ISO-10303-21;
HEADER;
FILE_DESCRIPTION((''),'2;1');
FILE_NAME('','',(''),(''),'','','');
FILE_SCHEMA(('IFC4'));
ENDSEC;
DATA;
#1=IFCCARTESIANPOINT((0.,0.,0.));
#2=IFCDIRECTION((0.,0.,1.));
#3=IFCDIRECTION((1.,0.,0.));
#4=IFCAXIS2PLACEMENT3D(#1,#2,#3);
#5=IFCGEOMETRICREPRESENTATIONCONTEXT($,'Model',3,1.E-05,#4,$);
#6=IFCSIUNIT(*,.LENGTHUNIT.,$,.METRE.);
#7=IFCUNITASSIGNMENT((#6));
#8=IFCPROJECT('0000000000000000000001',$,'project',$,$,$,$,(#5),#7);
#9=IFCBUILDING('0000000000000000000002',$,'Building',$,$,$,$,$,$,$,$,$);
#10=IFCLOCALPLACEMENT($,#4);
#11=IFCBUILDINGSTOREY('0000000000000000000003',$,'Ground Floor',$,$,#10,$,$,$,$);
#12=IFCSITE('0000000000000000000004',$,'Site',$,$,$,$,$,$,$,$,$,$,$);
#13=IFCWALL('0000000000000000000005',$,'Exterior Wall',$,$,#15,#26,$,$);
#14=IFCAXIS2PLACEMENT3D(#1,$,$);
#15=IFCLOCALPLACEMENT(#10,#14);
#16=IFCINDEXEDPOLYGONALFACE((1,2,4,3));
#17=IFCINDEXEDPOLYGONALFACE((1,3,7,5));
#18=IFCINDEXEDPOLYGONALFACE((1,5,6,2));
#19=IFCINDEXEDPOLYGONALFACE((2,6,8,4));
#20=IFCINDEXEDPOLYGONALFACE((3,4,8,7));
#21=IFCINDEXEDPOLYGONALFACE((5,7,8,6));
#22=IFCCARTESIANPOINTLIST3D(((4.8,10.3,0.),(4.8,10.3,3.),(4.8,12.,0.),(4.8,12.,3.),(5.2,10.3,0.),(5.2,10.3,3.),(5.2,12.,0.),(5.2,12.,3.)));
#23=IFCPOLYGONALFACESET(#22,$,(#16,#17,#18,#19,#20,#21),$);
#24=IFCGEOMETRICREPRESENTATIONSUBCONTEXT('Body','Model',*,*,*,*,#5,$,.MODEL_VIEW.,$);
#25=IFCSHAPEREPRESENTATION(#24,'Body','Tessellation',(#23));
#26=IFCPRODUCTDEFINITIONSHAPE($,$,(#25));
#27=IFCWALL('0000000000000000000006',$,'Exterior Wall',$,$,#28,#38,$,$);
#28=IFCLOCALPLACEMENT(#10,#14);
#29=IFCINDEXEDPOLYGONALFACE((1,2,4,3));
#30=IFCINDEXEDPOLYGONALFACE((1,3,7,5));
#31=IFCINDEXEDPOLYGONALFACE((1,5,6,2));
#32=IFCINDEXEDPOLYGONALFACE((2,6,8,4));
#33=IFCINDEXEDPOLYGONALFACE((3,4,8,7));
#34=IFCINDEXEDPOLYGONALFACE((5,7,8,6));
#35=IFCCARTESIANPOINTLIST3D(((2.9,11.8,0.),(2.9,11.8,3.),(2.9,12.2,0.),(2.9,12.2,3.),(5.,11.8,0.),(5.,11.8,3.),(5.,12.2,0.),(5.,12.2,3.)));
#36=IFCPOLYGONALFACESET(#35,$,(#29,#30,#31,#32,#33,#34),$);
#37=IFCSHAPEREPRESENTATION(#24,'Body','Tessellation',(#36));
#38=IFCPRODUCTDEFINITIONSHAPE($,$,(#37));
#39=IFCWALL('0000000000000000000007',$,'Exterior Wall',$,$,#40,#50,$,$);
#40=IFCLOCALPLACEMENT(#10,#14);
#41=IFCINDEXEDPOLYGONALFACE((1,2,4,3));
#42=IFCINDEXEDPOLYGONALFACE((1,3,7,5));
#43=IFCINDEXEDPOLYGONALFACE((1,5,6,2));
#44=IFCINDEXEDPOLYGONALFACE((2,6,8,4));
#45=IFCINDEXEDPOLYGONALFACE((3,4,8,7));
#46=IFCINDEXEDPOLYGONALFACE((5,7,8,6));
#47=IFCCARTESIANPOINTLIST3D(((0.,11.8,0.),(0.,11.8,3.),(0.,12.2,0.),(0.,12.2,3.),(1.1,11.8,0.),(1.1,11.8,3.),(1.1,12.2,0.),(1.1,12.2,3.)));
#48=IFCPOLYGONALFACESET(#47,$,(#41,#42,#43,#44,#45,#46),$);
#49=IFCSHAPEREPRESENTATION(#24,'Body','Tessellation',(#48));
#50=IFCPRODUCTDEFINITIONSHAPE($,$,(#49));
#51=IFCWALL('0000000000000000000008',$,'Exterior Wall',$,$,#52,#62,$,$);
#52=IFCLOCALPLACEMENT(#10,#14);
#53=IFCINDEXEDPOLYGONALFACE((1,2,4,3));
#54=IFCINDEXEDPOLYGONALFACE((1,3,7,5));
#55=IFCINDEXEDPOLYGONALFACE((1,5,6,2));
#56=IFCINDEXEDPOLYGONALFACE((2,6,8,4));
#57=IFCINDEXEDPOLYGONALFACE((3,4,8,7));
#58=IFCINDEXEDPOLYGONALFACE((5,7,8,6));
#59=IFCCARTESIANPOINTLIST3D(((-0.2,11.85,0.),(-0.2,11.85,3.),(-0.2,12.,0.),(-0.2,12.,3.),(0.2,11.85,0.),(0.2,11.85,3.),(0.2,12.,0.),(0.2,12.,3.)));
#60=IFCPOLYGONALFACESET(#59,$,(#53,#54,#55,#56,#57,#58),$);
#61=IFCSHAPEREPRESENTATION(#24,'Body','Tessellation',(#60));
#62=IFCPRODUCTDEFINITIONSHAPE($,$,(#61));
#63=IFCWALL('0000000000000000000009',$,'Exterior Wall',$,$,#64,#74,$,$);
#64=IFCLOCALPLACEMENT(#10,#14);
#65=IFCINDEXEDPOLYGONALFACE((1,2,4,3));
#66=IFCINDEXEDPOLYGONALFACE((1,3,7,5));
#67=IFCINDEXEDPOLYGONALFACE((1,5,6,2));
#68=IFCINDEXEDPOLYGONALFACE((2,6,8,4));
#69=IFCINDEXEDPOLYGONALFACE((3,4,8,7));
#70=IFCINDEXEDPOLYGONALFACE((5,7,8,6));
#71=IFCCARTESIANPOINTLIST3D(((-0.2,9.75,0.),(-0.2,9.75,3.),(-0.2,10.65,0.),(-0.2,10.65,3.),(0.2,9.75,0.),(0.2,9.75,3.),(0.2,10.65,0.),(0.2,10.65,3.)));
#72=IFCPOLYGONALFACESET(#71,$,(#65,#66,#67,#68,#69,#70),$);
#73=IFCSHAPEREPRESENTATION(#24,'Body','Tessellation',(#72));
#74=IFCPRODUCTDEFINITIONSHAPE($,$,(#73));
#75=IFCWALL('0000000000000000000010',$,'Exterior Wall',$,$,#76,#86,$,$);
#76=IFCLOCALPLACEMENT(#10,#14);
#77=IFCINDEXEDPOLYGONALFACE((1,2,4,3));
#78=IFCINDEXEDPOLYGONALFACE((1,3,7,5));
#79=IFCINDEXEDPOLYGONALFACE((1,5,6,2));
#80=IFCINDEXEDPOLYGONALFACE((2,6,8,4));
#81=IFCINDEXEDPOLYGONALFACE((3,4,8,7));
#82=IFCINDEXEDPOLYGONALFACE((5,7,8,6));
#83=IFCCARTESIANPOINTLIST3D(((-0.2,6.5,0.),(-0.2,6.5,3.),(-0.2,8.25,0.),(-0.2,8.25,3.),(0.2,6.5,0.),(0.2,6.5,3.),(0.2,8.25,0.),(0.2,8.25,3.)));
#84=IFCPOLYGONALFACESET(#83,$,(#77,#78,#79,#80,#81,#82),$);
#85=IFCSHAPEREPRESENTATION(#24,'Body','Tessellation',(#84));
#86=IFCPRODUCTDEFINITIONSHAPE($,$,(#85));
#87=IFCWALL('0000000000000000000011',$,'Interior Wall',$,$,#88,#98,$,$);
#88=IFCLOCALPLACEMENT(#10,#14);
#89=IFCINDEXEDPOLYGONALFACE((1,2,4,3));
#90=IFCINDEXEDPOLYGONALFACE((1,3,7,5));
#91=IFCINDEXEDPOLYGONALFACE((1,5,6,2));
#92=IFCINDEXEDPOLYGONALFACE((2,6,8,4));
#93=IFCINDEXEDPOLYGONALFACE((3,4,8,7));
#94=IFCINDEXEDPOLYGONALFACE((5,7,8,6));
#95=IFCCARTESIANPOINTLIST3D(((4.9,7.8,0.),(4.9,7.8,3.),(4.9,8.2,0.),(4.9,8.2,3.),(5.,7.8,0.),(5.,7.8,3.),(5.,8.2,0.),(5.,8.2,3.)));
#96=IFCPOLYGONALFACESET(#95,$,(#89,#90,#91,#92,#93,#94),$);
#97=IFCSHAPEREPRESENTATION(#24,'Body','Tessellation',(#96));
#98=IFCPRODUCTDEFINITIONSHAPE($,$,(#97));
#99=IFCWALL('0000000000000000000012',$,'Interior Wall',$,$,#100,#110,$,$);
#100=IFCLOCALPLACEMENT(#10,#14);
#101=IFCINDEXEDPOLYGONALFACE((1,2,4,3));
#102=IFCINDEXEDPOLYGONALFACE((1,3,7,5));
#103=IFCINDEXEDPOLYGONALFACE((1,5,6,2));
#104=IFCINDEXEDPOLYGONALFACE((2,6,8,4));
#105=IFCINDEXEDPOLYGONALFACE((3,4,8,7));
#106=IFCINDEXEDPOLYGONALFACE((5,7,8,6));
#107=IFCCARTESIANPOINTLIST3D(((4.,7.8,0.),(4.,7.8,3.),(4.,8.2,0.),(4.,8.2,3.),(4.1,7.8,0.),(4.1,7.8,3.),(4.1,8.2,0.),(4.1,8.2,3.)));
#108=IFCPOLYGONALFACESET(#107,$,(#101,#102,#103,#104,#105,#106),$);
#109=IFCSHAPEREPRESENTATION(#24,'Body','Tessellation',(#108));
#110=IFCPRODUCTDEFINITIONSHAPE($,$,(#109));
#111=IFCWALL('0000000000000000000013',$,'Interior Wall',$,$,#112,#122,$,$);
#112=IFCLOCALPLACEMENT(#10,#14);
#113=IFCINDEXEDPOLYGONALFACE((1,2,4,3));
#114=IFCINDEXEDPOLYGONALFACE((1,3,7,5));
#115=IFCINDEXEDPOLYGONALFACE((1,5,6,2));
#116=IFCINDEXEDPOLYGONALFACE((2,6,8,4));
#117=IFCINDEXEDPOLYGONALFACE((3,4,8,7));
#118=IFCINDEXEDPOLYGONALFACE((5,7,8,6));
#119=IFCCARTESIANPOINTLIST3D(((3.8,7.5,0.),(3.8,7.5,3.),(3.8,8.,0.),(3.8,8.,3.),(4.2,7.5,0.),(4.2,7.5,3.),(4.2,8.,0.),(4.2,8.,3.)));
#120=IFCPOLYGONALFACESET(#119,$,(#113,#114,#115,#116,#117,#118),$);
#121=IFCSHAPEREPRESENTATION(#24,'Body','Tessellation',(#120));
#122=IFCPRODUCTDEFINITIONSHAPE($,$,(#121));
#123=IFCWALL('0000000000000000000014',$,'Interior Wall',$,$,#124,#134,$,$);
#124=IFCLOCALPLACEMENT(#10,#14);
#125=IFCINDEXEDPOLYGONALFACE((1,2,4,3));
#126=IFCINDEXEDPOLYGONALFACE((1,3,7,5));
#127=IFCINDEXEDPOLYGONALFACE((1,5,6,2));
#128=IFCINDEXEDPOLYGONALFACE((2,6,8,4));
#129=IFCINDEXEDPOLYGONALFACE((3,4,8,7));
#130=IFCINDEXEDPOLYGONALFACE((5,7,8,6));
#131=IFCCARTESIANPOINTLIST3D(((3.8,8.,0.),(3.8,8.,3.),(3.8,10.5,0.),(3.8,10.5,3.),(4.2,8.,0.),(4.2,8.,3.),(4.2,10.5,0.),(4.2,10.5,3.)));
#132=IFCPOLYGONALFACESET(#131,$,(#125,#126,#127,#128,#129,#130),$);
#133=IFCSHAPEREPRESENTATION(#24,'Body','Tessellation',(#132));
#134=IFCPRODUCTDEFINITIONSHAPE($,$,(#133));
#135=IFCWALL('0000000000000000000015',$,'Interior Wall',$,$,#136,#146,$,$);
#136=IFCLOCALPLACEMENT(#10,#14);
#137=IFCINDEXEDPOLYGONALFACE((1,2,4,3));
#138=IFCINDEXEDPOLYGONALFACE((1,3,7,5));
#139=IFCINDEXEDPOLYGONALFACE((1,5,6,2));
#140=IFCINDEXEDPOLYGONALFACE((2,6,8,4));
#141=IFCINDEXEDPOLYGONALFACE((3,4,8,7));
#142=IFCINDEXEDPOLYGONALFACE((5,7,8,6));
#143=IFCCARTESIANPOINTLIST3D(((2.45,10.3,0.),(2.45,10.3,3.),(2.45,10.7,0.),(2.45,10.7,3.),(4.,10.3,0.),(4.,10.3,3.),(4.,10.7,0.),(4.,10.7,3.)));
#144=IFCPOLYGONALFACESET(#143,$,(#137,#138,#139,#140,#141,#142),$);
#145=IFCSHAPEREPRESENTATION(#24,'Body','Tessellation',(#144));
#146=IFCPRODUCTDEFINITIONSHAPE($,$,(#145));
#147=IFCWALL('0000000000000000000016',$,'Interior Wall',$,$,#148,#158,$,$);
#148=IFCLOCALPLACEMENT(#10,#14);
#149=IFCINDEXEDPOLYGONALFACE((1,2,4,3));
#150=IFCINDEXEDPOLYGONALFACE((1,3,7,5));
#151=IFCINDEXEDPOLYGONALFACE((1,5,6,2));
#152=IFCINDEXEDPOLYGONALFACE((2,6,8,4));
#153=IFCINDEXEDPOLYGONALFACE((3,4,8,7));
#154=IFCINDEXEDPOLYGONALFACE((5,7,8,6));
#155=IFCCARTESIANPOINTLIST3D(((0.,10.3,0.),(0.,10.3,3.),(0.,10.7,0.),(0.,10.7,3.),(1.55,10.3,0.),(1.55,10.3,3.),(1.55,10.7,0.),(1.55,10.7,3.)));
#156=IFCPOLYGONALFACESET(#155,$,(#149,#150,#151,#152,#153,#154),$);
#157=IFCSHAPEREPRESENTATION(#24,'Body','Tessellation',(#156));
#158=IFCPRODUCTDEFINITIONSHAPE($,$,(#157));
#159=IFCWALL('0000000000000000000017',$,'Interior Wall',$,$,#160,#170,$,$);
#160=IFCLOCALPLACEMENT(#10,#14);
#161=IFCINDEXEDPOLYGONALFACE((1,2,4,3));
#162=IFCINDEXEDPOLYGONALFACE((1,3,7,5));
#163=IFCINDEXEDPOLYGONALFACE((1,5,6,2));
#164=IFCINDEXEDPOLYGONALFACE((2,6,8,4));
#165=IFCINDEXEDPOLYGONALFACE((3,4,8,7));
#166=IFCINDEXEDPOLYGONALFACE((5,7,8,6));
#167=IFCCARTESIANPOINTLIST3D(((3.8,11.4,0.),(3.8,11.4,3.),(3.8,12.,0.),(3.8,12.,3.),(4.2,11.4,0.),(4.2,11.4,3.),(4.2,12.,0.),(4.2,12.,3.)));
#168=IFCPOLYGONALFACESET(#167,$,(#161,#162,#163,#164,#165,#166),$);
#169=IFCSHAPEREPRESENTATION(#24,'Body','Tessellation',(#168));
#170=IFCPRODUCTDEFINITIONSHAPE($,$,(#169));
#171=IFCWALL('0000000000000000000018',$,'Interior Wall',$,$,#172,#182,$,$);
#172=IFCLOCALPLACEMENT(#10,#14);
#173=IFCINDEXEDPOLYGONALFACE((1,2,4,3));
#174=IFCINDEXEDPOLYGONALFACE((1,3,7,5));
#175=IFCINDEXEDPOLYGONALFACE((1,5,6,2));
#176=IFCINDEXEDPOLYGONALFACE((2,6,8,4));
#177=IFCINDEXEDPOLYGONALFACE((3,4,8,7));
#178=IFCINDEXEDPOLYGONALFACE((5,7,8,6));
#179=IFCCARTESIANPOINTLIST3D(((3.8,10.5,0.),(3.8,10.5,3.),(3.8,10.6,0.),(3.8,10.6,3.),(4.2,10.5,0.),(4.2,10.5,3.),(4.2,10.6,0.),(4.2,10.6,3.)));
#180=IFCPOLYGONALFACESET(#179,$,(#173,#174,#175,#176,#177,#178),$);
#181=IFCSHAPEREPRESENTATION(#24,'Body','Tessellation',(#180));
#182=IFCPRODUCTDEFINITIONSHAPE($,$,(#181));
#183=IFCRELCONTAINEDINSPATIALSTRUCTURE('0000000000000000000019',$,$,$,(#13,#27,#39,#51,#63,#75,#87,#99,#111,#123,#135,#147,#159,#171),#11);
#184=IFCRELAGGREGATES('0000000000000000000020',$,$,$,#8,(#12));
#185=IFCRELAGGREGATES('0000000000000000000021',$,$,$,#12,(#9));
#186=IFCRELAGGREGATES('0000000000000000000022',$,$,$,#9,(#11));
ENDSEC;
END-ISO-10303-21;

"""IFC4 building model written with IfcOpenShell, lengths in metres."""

from ifc_helpers import new_model, si_unit, frame, origin_with_axes, place, context, subcontext, project, spatial, indexed_curve, outline, extrude, element, save


model = new_model("IFC4")

# Units and contexts
model_context = context("Model", 3, precision=1e-05, world=origin_with_axes())
body_context = subcontext(model_context, "Body", "Model", "MODEL_VIEW")
ifc_project = project(units=[si_unit("LENGTHUNIT", "METRE")], contexts=[model_context])

# Site, building, storey
site = spatial("IfcSite", under=ifc_project, Name="Site")
building = spatial("IfcBuilding", under=site, Name="Building")
storey_placement = place(None, origin_with_axes())
storey = spatial("IfcBuildingStorey", under=building, at=storey_placement, Name="Ground Floor")

# Walls
wall_1_placement = place(storey_placement, frame((5.0, 10.3, 0.0), z_axis=(0.0, 0.0, 1.0), x_axis=(0.0, 1.0, 0.0)))
element("IfcWall", 1, at=wall_1_placement, inside=storey, Name="Exterior Wall", context=body_context, shape_type="SweptSolid", body=[
    extrude(outline(indexed_curve([(0.0, 0.0), (0.0, 0.4), (1.7, 0.4), (1.7, 0.0), (0.0, 0.0)], self_intersect=False)), frame((0.0, -0.2, 0.0), z_axis=(0.0, 0.0, 1.0), x_axis=(1.0, 0.0, 0.0)), (0.0, 0.0, 1.0), 3.0),
])
wall_2_placement = place(storey_placement, frame((5.0, 12.0, 0.0), z_axis=(0.0, 0.0, 1.0), x_axis=(-1.0, 0.0, 0.0)))
element("IfcWall", 2, at=wall_2_placement, inside=storey, Name="Exterior Wall", context=body_context, shape_type="SweptSolid", body=[
    extrude(outline(indexed_curve([(0.0, 0.0), (0.0, 0.4), (2.1, 0.4), (2.1, 0.0), (0.0, 0.0)], self_intersect=False)), frame((0.0, -0.2, 0.0), z_axis=(0.0, 0.0, 1.0), x_axis=(1.0, 0.0, 0.0)), (0.0, 0.0, 1.0), 3.0),
])
wall_3_placement = place(storey_placement, frame((1.1, 12.0, 0.0), z_axis=(0.0, 0.0, 1.0), x_axis=(-1.0, 0.0, 0.0)))
element("IfcWall", 3, at=wall_3_placement, inside=storey, Name="Exterior Wall", context=body_context, shape_type="SweptSolid", body=[
    extrude(outline(indexed_curve([(0.0, 0.0), (0.0, 0.4), (1.1, 0.4), (1.1, 0.0), (0.0, 0.0)], self_intersect=False)), frame((0.0, -0.2, 0.0), z_axis=(0.0, 0.0, 1.0), x_axis=(1.0, 0.0, 0.0)), (0.0, 0.0, 1.0), 3.0),
])
wall_4_placement = place(storey_placement, frame((0.0, 12.0, 0.0), z_axis=(0.0, 0.0, 1.0), x_axis=(0.0, -1.0, 0.0)))
element("IfcWall", 4, at=wall_4_placement, inside=storey, Name="Exterior Wall", context=body_context, shape_type="SweptSolid", body=[
    extrude(outline(indexed_curve([(0.0, 0.0), (0.0, 0.4), (0.15, 0.4), (0.15, 0.0), (0.0, 0.0)], self_intersect=False)), frame((0.0, -0.2, 0.0), z_axis=(0.0, 0.0, 1.0), x_axis=(1.0, 0.0, 0.0)), (0.0, 0.0, 1.0), 3.0),
])
wall_5_placement = place(storey_placement, frame((0.0, 10.65, 0.0), z_axis=(0.0, 0.0, 1.0), x_axis=(0.0, -1.0, 0.0)))
element("IfcWall", 5, at=wall_5_placement, inside=storey, Name="Exterior Wall", context=body_context, shape_type="SweptSolid", body=[
    extrude(outline(indexed_curve([(0.0, 0.0), (0.0, 0.4), (0.9, 0.4), (0.9, 0.0), (0.0, 0.0)], self_intersect=False)), frame((0.0, -0.2, 0.0), z_axis=(0.0, 0.0, 1.0), x_axis=(1.0, 0.0, 0.0)), (0.0, 0.0, 1.0), 3.0),
])
wall_6_placement = place(storey_placement, frame((0.0, 8.25, 0.0), z_axis=(0.0, 0.0, 1.0), x_axis=(0.0, -1.0, 0.0)))
element("IfcWall", 6, at=wall_6_placement, inside=storey, Name="Exterior Wall", context=body_context, shape_type="SweptSolid", body=[
    extrude(outline(indexed_curve([(0.0, 0.0), (0.0, 0.4), (1.75, 0.4), (1.75, 0.0), (0.0, 0.0)], self_intersect=False)), frame((0.0, -0.2, 0.0), z_axis=(0.0, 0.0, 1.0), x_axis=(1.0, 0.0, 0.0)), (0.0, 0.0, 1.0), 3.0),
])
for number, where, z_axis, x_axis, name in (
    (7, (5.0, 8.0, 0.0), (0.0, 0.0, 1.0), (-1.0, 0.0, 0.0), "Interior Wall"),
    (8, (4.1, 8.0, 0.0), (0.0, 0.0, 1.0), (-1.0, 0.0, 0.0), "Interior Wall"),
):
    element("IfcWall", number, at=place(storey_placement, frame(where, z_axis=z_axis, x_axis=x_axis)), inside=storey, Name=name, context=body_context, shape_type="SweptSolid", body=[
        extrude(outline(indexed_curve([(0.0, 0.0), (0.0, 0.4), (0.1, 0.4), (0.1, 0.0), (0.0, 0.0)], self_intersect=False)), frame((0.0, -0.2, 0.0), z_axis=(0.0, 0.0, 1.0), x_axis=(1.0, 0.0, 0.0)), (0.0, 0.0, 1.0), 3.0),
    ])
wall_7_placement = place(storey_placement, frame((4.0, 8.0, 0.0), z_axis=(0.0, 0.0, 1.0), x_axis=(0.0, -1.0, 0.0)))
element("IfcWall", 9, at=wall_7_placement, inside=storey, Name="Interior Wall", context=body_context, shape_type="SweptSolid", body=[
    extrude(outline(indexed_curve([(0.0, 0.0), (0.0, 0.4), (0.5, 0.4), (0.5, 0.0), (0.0, 0.0)], self_intersect=False)), frame((0.0, -0.2, 0.0), z_axis=(0.0, 0.0, 1.0), x_axis=(1.0, 0.0, 0.0)), (0.0, 0.0, 1.0), 3.0),
])
wall_8_placement = place(storey_placement, frame((4.0, 8.0, 0.0), z_axis=(0.0, 0.0, 1.0), x_axis=(0.0, 1.0, 0.0)))
element("IfcWall", 10, at=wall_8_placement, inside=storey, Name="Interior Wall", context=body_context, shape_type="SweptSolid", body=[
    extrude(outline(indexed_curve([(0.0, 0.0), (0.0, 0.4), (2.5, 0.4), (2.5, 0.0), (0.0, 0.0)], self_intersect=False)), frame((0.0, -0.2, 0.0), z_axis=(0.0, 0.0, 1.0), x_axis=(1.0, 0.0, 0.0)), (0.0, 0.0, 1.0), 3.0),
])
for number, where, z_axis, x_axis, name in (
    (11, (4.0, 10.5, 0.0), (0.0, 0.0, 1.0), (-1.0, 0.0, 0.0), "Interior Wall"),
    (12, (1.55, 10.5, 0.0), (0.0, 0.0, 1.0), (-1.0, 0.0, 0.0), "Interior Wall"),
):
    element("IfcWall", number, at=place(storey_placement, frame(where, z_axis=z_axis, x_axis=x_axis)), inside=storey, Name=name, context=body_context, shape_type="SweptSolid", body=[
        extrude(outline(indexed_curve([(0.0, 0.0), (0.0, 0.4), (1.55, 0.4), (1.55, 0.0), (0.0, 0.0)], self_intersect=False)), frame((0.0, -0.2, 0.0), z_axis=(0.0, 0.0, 1.0), x_axis=(1.0, 0.0, 0.0)), (0.0, 0.0, 1.0), 3.0),
    ])
wall_9_placement = place(storey_placement, frame((4.0, 12.0, 0.0), z_axis=(0.0, 0.0, 1.0), x_axis=(0.0, -1.0, 0.0)))
element("IfcWall", 13, at=wall_9_placement, inside=storey, Name="Interior Wall", context=body_context, shape_type="SweptSolid", body=[
    extrude(outline(indexed_curve([(0.0, 0.0), (0.0, 0.4), (0.6, 0.4), (0.6, 0.0), (0.0, 0.0)], self_intersect=False)), frame((0.0, -0.2, 0.0), z_axis=(0.0, 0.0, 1.0), x_axis=(1.0, 0.0, 0.0)), (0.0, 0.0, 1.0), 3.0),
])
wall_10_placement = place(storey_placement, frame((4.0, 10.6, 0.0), z_axis=(0.0, 0.0, 1.0), x_axis=(0.0, -1.0, 0.0)))
element("IfcWall", 14, at=wall_10_placement, inside=storey, Name="Interior Wall", context=body_context, shape_type="SweptSolid", body=[
    extrude(outline(indexed_curve([(0.0, 0.0), (0.0, 0.4), (0.1, 0.4), (0.1, 0.0), (0.0, 0.0)], self_intersect=False)), frame((0.0, -0.2, 0.0), z_axis=(0.0, 0.0, 1.0), x_axis=(1.0, 0.0, 0.0)), (0.0, 0.0, 1.0), 3.0),
])

save(model, "model.ifc")
